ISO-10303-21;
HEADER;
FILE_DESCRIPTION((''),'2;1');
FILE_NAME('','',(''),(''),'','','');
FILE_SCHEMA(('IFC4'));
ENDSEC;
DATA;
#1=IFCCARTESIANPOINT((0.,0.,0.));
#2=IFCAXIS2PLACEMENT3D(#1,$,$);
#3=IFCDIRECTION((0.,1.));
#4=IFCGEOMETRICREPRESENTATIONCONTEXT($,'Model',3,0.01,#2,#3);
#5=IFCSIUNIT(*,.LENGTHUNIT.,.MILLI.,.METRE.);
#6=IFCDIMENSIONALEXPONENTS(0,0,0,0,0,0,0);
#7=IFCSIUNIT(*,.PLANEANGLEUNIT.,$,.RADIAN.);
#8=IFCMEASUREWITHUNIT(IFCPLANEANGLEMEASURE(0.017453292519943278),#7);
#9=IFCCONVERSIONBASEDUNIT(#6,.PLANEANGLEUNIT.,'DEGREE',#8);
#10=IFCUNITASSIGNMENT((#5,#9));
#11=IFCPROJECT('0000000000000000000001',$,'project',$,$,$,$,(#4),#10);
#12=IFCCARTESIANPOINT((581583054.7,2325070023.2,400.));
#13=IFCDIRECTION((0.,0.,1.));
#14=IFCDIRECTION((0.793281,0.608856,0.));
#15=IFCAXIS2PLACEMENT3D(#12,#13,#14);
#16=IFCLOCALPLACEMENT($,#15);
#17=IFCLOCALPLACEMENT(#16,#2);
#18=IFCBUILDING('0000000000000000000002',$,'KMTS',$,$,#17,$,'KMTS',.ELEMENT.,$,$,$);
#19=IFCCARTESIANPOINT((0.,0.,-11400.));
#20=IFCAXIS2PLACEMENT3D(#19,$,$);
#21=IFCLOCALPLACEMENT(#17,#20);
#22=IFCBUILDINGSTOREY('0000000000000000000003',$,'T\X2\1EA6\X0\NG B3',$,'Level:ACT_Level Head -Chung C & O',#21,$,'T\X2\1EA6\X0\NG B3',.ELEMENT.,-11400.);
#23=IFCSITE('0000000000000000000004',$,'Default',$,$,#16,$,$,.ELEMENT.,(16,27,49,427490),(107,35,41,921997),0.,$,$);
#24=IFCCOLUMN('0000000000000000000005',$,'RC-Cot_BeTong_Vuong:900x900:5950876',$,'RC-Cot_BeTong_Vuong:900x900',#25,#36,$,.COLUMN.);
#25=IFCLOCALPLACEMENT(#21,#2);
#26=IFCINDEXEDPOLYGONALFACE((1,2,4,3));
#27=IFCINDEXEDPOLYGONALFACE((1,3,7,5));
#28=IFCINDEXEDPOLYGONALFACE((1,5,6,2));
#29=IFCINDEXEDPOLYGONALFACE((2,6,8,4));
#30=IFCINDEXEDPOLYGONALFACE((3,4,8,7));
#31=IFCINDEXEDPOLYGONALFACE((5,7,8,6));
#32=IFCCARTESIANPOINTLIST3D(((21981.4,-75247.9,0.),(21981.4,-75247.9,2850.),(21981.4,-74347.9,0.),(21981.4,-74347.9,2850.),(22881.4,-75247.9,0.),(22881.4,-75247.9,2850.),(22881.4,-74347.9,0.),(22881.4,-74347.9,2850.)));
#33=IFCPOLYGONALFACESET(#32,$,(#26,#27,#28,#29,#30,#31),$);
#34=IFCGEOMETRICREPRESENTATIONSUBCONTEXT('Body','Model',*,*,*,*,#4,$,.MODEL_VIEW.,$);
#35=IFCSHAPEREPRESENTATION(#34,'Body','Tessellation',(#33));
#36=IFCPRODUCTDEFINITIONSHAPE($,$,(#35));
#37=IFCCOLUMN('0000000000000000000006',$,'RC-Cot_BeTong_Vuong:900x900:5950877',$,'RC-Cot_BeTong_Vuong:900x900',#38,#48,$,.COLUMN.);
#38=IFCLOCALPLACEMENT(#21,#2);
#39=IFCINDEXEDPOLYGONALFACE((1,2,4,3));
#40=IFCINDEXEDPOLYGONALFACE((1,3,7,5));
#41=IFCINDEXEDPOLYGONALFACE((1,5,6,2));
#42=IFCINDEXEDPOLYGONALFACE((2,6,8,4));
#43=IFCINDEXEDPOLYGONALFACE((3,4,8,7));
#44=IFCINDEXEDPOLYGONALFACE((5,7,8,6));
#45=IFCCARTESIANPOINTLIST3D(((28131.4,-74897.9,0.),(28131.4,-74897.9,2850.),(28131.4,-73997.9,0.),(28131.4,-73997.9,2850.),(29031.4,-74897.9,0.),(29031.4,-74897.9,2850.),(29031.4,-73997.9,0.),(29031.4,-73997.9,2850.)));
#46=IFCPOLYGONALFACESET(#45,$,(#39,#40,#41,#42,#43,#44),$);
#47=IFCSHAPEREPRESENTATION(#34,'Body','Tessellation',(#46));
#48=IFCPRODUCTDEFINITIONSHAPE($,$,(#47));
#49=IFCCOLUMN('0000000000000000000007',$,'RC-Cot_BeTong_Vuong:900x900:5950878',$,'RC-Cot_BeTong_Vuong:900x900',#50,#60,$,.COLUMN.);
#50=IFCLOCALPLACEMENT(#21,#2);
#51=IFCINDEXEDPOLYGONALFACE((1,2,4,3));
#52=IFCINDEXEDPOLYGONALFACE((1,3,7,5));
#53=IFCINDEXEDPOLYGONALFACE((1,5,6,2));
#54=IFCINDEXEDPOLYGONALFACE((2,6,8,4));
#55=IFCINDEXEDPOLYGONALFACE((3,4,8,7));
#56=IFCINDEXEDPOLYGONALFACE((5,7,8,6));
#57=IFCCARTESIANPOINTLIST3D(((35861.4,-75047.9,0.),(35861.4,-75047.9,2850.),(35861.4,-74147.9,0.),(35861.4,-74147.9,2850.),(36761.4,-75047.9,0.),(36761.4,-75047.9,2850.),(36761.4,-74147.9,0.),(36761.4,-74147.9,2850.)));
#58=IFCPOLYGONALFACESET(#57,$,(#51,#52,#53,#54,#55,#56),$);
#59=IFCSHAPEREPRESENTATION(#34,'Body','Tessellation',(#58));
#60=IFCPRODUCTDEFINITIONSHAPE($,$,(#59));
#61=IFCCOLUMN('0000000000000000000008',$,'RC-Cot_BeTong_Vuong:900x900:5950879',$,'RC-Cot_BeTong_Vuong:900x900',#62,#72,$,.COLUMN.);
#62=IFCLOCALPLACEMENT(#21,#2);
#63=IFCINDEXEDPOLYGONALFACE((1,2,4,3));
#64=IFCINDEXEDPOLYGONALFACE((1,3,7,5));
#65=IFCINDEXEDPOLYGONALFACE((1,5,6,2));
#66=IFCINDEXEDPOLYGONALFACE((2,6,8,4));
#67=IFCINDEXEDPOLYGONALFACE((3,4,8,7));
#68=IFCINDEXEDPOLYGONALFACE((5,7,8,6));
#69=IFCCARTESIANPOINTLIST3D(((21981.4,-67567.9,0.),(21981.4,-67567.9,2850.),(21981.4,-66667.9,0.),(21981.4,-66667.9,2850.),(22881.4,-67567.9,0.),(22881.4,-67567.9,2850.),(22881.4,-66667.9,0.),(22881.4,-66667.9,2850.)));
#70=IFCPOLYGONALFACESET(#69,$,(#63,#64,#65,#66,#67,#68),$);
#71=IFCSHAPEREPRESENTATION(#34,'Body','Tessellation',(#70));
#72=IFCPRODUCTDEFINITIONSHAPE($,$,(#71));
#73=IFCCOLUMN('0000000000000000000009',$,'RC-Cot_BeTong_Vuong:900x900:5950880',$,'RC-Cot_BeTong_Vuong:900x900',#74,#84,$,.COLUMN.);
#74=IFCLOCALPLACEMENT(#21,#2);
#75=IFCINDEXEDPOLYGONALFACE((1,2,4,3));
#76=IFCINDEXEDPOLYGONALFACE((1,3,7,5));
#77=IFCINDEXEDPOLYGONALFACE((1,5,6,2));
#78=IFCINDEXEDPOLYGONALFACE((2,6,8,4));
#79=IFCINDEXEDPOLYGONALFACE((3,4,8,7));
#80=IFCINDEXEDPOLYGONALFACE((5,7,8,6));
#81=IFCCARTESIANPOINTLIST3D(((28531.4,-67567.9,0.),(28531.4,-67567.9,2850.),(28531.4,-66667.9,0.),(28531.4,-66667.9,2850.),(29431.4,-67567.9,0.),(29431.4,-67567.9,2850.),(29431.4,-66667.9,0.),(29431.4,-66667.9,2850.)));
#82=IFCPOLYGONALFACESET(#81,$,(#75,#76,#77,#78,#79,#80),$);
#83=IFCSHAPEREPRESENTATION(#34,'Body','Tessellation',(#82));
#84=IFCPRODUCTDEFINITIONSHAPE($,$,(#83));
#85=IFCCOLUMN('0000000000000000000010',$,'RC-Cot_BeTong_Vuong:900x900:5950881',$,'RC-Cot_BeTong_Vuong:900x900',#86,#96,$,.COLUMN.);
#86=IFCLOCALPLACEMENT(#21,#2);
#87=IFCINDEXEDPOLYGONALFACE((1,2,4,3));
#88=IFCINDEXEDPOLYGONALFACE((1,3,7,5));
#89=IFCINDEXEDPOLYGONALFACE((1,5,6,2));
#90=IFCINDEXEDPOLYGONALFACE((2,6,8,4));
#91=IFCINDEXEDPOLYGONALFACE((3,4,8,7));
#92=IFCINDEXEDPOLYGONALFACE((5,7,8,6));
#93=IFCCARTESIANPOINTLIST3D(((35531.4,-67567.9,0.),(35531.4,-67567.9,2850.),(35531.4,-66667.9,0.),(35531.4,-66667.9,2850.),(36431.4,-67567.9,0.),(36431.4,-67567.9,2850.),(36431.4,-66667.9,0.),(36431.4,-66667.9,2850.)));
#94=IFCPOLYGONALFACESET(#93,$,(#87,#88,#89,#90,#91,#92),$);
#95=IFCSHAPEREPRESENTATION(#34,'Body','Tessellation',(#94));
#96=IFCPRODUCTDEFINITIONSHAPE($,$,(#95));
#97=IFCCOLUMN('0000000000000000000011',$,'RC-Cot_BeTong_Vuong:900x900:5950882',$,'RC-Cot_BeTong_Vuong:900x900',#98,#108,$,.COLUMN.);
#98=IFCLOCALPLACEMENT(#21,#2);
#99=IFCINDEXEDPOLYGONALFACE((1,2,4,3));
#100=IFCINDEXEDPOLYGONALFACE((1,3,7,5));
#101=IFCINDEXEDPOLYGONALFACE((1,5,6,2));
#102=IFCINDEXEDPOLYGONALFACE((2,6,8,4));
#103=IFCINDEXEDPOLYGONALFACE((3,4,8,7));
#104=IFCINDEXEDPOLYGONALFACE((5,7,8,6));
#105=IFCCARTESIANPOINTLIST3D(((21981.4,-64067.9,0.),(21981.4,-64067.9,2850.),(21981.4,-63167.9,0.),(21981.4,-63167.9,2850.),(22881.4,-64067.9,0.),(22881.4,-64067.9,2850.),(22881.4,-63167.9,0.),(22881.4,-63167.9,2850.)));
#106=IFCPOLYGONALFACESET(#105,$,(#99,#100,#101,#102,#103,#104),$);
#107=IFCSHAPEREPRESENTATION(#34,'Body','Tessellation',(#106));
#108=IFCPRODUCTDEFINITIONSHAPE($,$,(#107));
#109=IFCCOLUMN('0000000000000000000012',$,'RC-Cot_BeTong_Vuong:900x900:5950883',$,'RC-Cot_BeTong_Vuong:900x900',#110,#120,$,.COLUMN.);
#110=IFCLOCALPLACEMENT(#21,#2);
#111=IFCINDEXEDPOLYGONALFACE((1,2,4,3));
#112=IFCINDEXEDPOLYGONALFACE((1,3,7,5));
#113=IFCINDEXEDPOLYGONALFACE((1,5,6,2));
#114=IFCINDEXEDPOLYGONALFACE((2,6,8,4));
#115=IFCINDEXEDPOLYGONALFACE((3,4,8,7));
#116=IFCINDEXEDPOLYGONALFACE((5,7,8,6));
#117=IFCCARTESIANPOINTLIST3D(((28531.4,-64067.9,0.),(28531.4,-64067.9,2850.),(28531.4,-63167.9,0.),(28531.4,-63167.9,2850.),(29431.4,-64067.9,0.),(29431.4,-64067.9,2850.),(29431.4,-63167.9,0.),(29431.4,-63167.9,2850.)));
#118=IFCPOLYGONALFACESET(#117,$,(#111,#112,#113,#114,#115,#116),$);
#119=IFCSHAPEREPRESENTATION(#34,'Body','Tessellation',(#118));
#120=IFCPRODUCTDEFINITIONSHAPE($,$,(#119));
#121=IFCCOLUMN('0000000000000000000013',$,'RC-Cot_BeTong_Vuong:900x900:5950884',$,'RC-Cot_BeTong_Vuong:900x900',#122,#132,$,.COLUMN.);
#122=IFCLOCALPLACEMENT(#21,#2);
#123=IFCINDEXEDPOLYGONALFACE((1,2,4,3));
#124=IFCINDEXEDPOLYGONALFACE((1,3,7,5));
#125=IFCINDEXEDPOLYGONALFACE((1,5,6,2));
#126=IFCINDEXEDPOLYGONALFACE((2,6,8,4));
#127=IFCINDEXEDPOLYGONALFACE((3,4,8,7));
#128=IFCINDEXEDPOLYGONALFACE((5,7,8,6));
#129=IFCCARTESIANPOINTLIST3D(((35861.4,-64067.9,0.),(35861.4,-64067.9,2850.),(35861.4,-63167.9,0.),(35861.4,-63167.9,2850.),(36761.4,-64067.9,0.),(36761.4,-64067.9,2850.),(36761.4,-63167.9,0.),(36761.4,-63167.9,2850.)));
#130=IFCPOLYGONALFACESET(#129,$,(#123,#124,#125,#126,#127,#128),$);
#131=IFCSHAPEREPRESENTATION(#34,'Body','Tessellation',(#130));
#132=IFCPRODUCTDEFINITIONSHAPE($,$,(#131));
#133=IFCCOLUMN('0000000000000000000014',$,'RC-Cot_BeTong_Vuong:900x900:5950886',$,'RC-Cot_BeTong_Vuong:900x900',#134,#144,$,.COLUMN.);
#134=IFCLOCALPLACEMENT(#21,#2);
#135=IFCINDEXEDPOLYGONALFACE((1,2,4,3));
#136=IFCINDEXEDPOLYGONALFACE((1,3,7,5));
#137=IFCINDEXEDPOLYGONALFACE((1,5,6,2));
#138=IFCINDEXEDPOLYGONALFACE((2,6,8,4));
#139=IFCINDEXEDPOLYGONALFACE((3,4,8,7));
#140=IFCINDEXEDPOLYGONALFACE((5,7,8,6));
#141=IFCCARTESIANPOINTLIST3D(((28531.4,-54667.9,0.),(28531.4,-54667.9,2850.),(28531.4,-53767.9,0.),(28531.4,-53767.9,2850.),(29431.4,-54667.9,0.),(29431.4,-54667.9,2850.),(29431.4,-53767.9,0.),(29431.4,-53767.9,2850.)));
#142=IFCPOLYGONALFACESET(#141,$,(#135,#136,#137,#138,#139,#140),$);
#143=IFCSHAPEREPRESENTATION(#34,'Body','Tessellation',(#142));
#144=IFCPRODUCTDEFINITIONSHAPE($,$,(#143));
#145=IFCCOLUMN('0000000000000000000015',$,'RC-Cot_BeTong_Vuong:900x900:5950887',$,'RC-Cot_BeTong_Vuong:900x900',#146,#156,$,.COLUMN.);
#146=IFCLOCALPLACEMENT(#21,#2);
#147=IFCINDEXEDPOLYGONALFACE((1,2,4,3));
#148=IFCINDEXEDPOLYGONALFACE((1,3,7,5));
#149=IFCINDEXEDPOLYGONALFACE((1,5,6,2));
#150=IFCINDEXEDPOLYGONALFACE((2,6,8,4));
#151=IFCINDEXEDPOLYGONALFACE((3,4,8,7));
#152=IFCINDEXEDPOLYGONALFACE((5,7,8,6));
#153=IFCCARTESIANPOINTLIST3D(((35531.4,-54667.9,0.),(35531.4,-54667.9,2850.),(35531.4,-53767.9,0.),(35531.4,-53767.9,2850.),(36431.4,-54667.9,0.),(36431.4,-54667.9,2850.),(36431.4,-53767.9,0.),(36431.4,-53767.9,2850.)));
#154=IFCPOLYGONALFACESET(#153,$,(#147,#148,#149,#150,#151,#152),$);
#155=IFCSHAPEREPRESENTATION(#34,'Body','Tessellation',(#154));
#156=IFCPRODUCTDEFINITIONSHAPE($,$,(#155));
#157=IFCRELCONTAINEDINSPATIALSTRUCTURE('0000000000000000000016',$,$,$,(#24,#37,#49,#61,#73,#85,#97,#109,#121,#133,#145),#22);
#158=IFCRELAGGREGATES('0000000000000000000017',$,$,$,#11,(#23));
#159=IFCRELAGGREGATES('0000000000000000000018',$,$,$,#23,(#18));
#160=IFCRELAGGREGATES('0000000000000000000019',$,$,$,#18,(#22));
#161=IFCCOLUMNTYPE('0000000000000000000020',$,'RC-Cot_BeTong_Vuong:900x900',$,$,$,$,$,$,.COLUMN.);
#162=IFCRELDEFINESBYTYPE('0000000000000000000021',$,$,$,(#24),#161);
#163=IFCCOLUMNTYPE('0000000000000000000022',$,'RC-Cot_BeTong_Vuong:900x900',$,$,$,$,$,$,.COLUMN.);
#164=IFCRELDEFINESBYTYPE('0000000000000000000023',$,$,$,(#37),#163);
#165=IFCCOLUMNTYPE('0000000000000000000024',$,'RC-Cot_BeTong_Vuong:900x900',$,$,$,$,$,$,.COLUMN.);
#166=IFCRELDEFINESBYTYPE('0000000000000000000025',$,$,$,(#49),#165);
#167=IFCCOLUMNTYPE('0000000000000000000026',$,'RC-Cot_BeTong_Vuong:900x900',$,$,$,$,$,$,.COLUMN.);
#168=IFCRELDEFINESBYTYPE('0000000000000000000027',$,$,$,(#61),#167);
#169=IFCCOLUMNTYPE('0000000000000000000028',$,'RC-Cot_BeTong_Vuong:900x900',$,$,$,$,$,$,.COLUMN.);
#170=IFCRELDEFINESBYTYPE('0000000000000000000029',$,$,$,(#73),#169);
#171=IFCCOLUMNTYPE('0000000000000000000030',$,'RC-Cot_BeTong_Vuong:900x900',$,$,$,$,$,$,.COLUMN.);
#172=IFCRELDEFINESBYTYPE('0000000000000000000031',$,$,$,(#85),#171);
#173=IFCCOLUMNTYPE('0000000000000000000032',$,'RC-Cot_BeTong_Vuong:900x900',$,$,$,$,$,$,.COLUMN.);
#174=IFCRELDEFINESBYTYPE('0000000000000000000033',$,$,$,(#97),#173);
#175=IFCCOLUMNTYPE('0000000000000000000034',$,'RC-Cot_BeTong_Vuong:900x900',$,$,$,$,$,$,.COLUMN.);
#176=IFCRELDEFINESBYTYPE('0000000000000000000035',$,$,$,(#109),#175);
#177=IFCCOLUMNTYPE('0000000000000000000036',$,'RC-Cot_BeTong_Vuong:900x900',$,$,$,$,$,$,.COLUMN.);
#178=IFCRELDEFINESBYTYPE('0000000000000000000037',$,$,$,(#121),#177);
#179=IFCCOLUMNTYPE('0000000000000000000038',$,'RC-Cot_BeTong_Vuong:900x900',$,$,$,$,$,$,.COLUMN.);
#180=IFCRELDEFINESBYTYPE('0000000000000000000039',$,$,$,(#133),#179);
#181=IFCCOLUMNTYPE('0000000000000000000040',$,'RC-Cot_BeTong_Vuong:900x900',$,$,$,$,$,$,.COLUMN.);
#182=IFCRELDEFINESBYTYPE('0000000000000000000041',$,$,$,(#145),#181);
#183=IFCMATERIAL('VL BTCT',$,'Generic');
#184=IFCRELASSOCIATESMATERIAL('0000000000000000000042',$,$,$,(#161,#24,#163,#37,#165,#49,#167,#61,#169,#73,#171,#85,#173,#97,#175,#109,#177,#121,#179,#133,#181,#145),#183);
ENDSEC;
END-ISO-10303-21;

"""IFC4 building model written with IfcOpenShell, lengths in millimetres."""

from ifc_helpers import new_model, entity, si_unit, converted_unit, direction, frame, origin, place, context, subcontext, project, spatial, indexed_curve, outline, extrude, source, transform, mapped, material, type_object, type_shapes, element, save


model = new_model("IFC4")

# Units and contexts
model_context = context("Model", 3, precision=0.01, world=origin(), true_north=direction((0.0, 1.0)))
body_context = subcontext(model_context, "Body", "Model", "MODEL_VIEW")
ifc_project = project(units=[si_unit("LENGTHUNIT", "METRE", prefix="MILLI"), converted_unit("PLANEANGLEUNIT", "DEGREE", entity("IfcPlaneAngleMeasure", 0.017453292519943278), si_unit("PLANEANGLEUNIT", "RADIAN"), dimensions=[0, 0, 0, 0, 0, 0, 0])], contexts=[model_context])

# Site, building, storey
site_placement = place(None, frame((581583054.7, 2325070023.2, 400.0), z_axis=(0.0, 0.0, 1.0), x_axis=(0.793281, 0.608856, 0.0)))
site = spatial("IfcSite", under=ifc_project, at=site_placement, Name="Default", CompositionType="ELEMENT", RefLatitude=(16, 27, 49, 427490), RefLongitude=(107, 35, 41, 921997), RefElevation=0.0)
building_placement = place(site_placement, origin())
building = spatial("IfcBuilding", under=site, at=building_placement, Name="KMTS", LongName="KMTS", CompositionType="ELEMENT")
storey_placement = place(building_placement, frame((0.0, 0.0, -11400.0)))
storey = spatial("IfcBuildingStorey", under=building, at=storey_placement, Name="TẦNG B3", ObjectType="Level:ACT_Level Head -Chung C & O", LongName="TẦNG B3", CompositionType="ELEMENT", Elevation=-11400.0)

# Columns
ifc_material = material(Name="VL BTCT", Category="Generic")
column_type_1 = type_object("IfcColumnType", Name="RC-Cot_BeTong_Vuong:900x900", PredefinedType="COLUMN", material=ifc_material)
shared_shape_1 = source(origin(), body_context, "Body", "SweptSolid", [
    extrude(outline(indexed_curve([(-450.0, -450.0), (450.0, -450.0), (450.0, 450.0), (-450.0, 450.0), (-450.0, -450.0)], self_intersect=False)), frame((22431.4, -74797.9, -11400.0), z_axis=(0.0, 0.0, 1.0), x_axis=(-1.0, 0.0, 0.0)), (0.0, 0.0, 1.0), 2850.0),
])
type_shapes(column_type_1, [shared_shape_1])
column_1_placement = place(storey_placement, frame((0.0, 0.0, 11400.0)))
element("IfcColumn", 1, at=column_1_placement, inside=storey, type_object=column_type_1, material=ifc_material, Name="RC-Cot_BeTong_Vuong:900x900:5950876", ObjectType="RC-Cot_BeTong_Vuong:900x900", PredefinedType="COLUMN", context=body_context, shape_type="MappedRepresentation", body=[
    mapped(shared_shape_1, transform((0.0, 0.0, 0.0), scale=1.0)),
])
column_type_2 = type_object("IfcColumnType", Name="RC-Cot_BeTong_Vuong:900x900", PredefinedType="COLUMN", material=ifc_material)
shared_shape_2 = source(origin(), body_context, "Body", "SweptSolid", [
    extrude(outline(indexed_curve([(-450.0, -450.0), (450.0, -450.0), (450.0, 450.0), (-450.0, 450.0), (-450.0, -450.0)], self_intersect=False)), frame((28581.4, -74447.9, -11400.0), z_axis=(0.0, 0.0, 1.0), x_axis=(-1.0, 0.0, 0.0)), (0.0, 0.0, 1.0), 2850.0),
])
type_shapes(column_type_2, [shared_shape_2])
column_2_placement = place(storey_placement, frame((0.0, 0.0, 11400.0)))
element("IfcColumn", 2, at=column_2_placement, inside=storey, type_object=column_type_2, material=ifc_material, Name="RC-Cot_BeTong_Vuong:900x900:5950877", ObjectType="RC-Cot_BeTong_Vuong:900x900", PredefinedType="COLUMN", context=body_context, shape_type="MappedRepresentation", body=[
    mapped(shared_shape_2, transform((0.0, 0.0, 0.0), scale=1.0)),
])
column_type_3 = type_object("IfcColumnType", Name="RC-Cot_BeTong_Vuong:900x900", PredefinedType="COLUMN", material=ifc_material)
shared_shape_3 = source(origin(), body_context, "Body", "SweptSolid", [
    extrude(outline(indexed_curve([(-450.0, -450.0), (450.0, -450.0), (450.0, 450.0), (-450.0, 450.0), (-450.0, -450.0)], self_intersect=False)), frame((36311.4, -74597.9, -11400.0), z_axis=(0.0, 0.0, 1.0), x_axis=(-1.0, 0.0, 0.0)), (0.0, 0.0, 1.0), 2850.0),
])
type_shapes(column_type_3, [shared_shape_3])
column_3_placement = place(storey_placement, frame((0.0, 0.0, 11400.0)))
element("IfcColumn", 3, at=column_3_placement, inside=storey, type_object=column_type_3, material=ifc_material, Name="RC-Cot_BeTong_Vuong:900x900:5950878", ObjectType="RC-Cot_BeTong_Vuong:900x900", PredefinedType="COLUMN", context=body_context, shape_type="MappedRepresentation", body=[
    mapped(shared_shape_3, transform((0.0, 0.0, 0.0), scale=1.0)),
])
column_type_4 = type_object("IfcColumnType", Name="RC-Cot_BeTong_Vuong:900x900", PredefinedType="COLUMN", material=ifc_material)
shared_shape_4 = source(origin(), body_context, "Body", "SweptSolid", [
    extrude(outline(indexed_curve([(-450.0, -450.0), (450.0, -450.0), (450.0, 450.0), (-450.0, 450.0), (-450.0, -450.0)], self_intersect=False)), frame((22431.4, -67117.9, -11400.0), z_axis=(0.0, 0.0, 1.0), x_axis=(-1.0, 0.0, 0.0)), (0.0, 0.0, 1.0), 2850.0),
])
type_shapes(column_type_4, [shared_shape_4])
column_4_placement = place(storey_placement, frame((0.0, 0.0, 11400.0)))
element("IfcColumn", 4, at=column_4_placement, inside=storey, type_object=column_type_4, material=ifc_material, Name="RC-Cot_BeTong_Vuong:900x900:5950879", ObjectType="RC-Cot_BeTong_Vuong:900x900", PredefinedType="COLUMN", context=body_context, shape_type="MappedRepresentation", body=[
    mapped(shared_shape_4, transform((0.0, 0.0, 0.0), scale=1.0)),
])
column_type_5 = type_object("IfcColumnType", Name="RC-Cot_BeTong_Vuong:900x900", PredefinedType="COLUMN", material=ifc_material)
shared_shape_5 = source(origin(), body_context, "Body", "SweptSolid", [
    extrude(outline(indexed_curve([(-450.0, -450.0), (450.0, -450.0), (450.0, 450.0), (-450.0, 450.0), (-450.0, -450.0)], self_intersect=False)), frame((28981.4, -67117.9, -11400.0), z_axis=(0.0, 0.0, 1.0), x_axis=(-1.0, 0.0, 0.0)), (0.0, 0.0, 1.0), 2850.0),
])
type_shapes(column_type_5, [shared_shape_5])
column_5_placement = place(storey_placement, frame((0.0, 0.0, 11400.0)))
element("IfcColumn", 5, at=column_5_placement, inside=storey, type_object=column_type_5, material=ifc_material, Name="RC-Cot_BeTong_Vuong:900x900:5950880", ObjectType="RC-Cot_BeTong_Vuong:900x900", PredefinedType="COLUMN", context=body_context, shape_type="MappedRepresentation", body=[
    mapped(shared_shape_5, transform((0.0, 0.0, 0.0), scale=1.0)),
])
column_type_6 = type_object("IfcColumnType", Name="RC-Cot_BeTong_Vuong:900x900", PredefinedType="COLUMN", material=ifc_material)
shared_shape_6 = source(origin(), body_context, "Body", "SweptSolid", [
    extrude(outline(indexed_curve([(-450.0, -450.0), (450.0, -450.0), (450.0, 450.0), (-450.0, 450.0), (-450.0, -450.0)], self_intersect=False)), frame((35981.4, -67117.9, -11400.0), z_axis=(0.0, 0.0, 1.0), x_axis=(-1.0, 0.0, 0.0)), (0.0, 0.0, 1.0), 2850.0),
])
type_shapes(column_type_6, [shared_shape_6])
column_6_placement = place(storey_placement, frame((0.0, 0.0, 11400.0)))
element("IfcColumn", 6, at=column_6_placement, inside=storey, type_object=column_type_6, material=ifc_material, Name="RC-Cot_BeTong_Vuong:900x900:5950881", ObjectType="RC-Cot_BeTong_Vuong:900x900", PredefinedType="COLUMN", context=body_context, shape_type="MappedRepresentation", body=[
    mapped(shared_shape_6, transform((0.0, 0.0, 0.0), scale=1.0)),
])
column_type_7 = type_object("IfcColumnType", Name="RC-Cot_BeTong_Vuong:900x900", PredefinedType="COLUMN", material=ifc_material)
shared_shape_7 = source(origin(), body_context, "Body", "SweptSolid", [
    extrude(outline(indexed_curve([(-450.0, -450.0), (450.0, -450.0), (450.0, 450.0), (-450.0, 450.0), (-450.0, -450.0)], self_intersect=False)), frame((22431.4, -63617.9, -11400.0), z_axis=(0.0, 0.0, 1.0), x_axis=(-1.0, 0.0, 0.0)), (0.0, 0.0, 1.0), 2850.0),
])
type_shapes(column_type_7, [shared_shape_7])
column_7_placement = place(storey_placement, frame((0.0, 0.0, 11400.0)))
element("IfcColumn", 7, at=column_7_placement, inside=storey, type_object=column_type_7, material=ifc_material, Name="RC-Cot_BeTong_Vuong:900x900:5950882", ObjectType="RC-Cot_BeTong_Vuong:900x900", PredefinedType="COLUMN", context=body_context, shape_type="MappedRepresentation", body=[
    mapped(shared_shape_7, transform((0.0, 0.0, 0.0), scale=1.0)),
])
column_type_8 = type_object("IfcColumnType", Name="RC-Cot_BeTong_Vuong:900x900", PredefinedType="COLUMN", material=ifc_material)
shared_shape_8 = source(origin(), body_context, "Body", "SweptSolid", [
    extrude(outline(indexed_curve([(-450.0, -450.0), (450.0, -450.0), (450.0, 450.0), (-450.0, 450.0), (-450.0, -450.0)], self_intersect=False)), frame((28981.4, -63617.9, -11400.0), z_axis=(0.0, 0.0, 1.0), x_axis=(-1.0, 0.0, 0.0)), (0.0, 0.0, 1.0), 2850.0),
])
type_shapes(column_type_8, [shared_shape_8])
column_8_placement = place(storey_placement, frame((0.0, 0.0, 11400.0)))
element("IfcColumn", 8, at=column_8_placement, inside=storey, type_object=column_type_8, material=ifc_material, Name="RC-Cot_BeTong_Vuong:900x900:5950883", ObjectType="RC-Cot_BeTong_Vuong:900x900", PredefinedType="COLUMN", context=body_context, shape_type="MappedRepresentation", body=[
    mapped(shared_shape_8, transform((0.0, 0.0, 0.0), scale=1.0)),
])
column_type_9 = type_object("IfcColumnType", Name="RC-Cot_BeTong_Vuong:900x900", PredefinedType="COLUMN", material=ifc_material)
shared_shape_9 = source(origin(), body_context, "Body", "SweptSolid", [
    extrude(outline(indexed_curve([(-450.0, -450.0), (450.0, -450.0), (450.0, 450.0), (-450.0, 450.0), (-450.0, -450.0)], self_intersect=False)), frame((36311.4, -63617.9, -11400.0), z_axis=(0.0, 0.0, 1.0), x_axis=(-1.0, 0.0, 0.0)), (0.0, 0.0, 1.0), 2850.0),
])
type_shapes(column_type_9, [shared_shape_9])
column_9_placement = place(storey_placement, frame((0.0, 0.0, 11400.0)))
element("IfcColumn", 9, at=column_9_placement, inside=storey, type_object=column_type_9, material=ifc_material, Name="RC-Cot_BeTong_Vuong:900x900:5950884", ObjectType="RC-Cot_BeTong_Vuong:900x900", PredefinedType="COLUMN", context=body_context, shape_type="MappedRepresentation", body=[
    mapped(shared_shape_9, transform((0.0, 0.0, 0.0), scale=1.0)),
])
column_type_10 = type_object("IfcColumnType", Name="RC-Cot_BeTong_Vuong:900x900", PredefinedType="COLUMN", material=ifc_material)
shared_shape_10 = source(origin(), body_context, "Body", "SweptSolid", [
    extrude(outline(indexed_curve([(-450.0, -450.0), (450.0, -450.0), (450.0, 450.0), (-450.0, 450.0), (-450.0, -450.0)], self_intersect=False)), frame((28981.4, -54217.9, -11400.0), z_axis=(0.0, 0.0, 1.0), x_axis=(-1.0, 0.0, 0.0)), (0.0, 0.0, 1.0), 2850.0),
])
type_shapes(column_type_10, [shared_shape_10])
column_10_placement = place(storey_placement, frame((0.0, 0.0, 11400.0)))
element("IfcColumn", 10, at=column_10_placement, inside=storey, type_object=column_type_10, material=ifc_material, Name="RC-Cot_BeTong_Vuong:900x900:5950886", ObjectType="RC-Cot_BeTong_Vuong:900x900", PredefinedType="COLUMN", context=body_context, shape_type="MappedRepresentation", body=[
    mapped(shared_shape_10, transform((0.0, 0.0, 0.0), scale=1.0)),
])
column_type_11 = type_object("IfcColumnType", Name="RC-Cot_BeTong_Vuong:900x900", PredefinedType="COLUMN", material=ifc_material)
shared_shape_11 = source(origin(), body_context, "Body", "SweptSolid", [
    extrude(outline(indexed_curve([(-450.0, -450.0), (450.0, -450.0), (450.0, 450.0), (-450.0, 450.0), (-450.0, -450.0)], self_intersect=False)), frame((35981.4, -54217.9, -11400.0), z_axis=(0.0, 0.0, 1.0), x_axis=(-1.0, 0.0, 0.0)), (0.0, 0.0, 1.0), 2850.0),
])
type_shapes(column_type_11, [shared_shape_11])
column_11_placement = place(storey_placement, frame((0.0, 0.0, 11400.0)))
element("IfcColumn", 11, at=column_11_placement, inside=storey, type_object=column_type_11, material=ifc_material, Name="RC-Cot_BeTong_Vuong:900x900:5950887", ObjectType="RC-Cot_BeTong_Vuong:900x900", PredefinedType="COLUMN", context=body_context, shape_type="MappedRepresentation", body=[
    mapped(shared_shape_11, transform((0.0, 0.0, 0.0), scale=1.0)),
])

save(model, "model.ifc")
